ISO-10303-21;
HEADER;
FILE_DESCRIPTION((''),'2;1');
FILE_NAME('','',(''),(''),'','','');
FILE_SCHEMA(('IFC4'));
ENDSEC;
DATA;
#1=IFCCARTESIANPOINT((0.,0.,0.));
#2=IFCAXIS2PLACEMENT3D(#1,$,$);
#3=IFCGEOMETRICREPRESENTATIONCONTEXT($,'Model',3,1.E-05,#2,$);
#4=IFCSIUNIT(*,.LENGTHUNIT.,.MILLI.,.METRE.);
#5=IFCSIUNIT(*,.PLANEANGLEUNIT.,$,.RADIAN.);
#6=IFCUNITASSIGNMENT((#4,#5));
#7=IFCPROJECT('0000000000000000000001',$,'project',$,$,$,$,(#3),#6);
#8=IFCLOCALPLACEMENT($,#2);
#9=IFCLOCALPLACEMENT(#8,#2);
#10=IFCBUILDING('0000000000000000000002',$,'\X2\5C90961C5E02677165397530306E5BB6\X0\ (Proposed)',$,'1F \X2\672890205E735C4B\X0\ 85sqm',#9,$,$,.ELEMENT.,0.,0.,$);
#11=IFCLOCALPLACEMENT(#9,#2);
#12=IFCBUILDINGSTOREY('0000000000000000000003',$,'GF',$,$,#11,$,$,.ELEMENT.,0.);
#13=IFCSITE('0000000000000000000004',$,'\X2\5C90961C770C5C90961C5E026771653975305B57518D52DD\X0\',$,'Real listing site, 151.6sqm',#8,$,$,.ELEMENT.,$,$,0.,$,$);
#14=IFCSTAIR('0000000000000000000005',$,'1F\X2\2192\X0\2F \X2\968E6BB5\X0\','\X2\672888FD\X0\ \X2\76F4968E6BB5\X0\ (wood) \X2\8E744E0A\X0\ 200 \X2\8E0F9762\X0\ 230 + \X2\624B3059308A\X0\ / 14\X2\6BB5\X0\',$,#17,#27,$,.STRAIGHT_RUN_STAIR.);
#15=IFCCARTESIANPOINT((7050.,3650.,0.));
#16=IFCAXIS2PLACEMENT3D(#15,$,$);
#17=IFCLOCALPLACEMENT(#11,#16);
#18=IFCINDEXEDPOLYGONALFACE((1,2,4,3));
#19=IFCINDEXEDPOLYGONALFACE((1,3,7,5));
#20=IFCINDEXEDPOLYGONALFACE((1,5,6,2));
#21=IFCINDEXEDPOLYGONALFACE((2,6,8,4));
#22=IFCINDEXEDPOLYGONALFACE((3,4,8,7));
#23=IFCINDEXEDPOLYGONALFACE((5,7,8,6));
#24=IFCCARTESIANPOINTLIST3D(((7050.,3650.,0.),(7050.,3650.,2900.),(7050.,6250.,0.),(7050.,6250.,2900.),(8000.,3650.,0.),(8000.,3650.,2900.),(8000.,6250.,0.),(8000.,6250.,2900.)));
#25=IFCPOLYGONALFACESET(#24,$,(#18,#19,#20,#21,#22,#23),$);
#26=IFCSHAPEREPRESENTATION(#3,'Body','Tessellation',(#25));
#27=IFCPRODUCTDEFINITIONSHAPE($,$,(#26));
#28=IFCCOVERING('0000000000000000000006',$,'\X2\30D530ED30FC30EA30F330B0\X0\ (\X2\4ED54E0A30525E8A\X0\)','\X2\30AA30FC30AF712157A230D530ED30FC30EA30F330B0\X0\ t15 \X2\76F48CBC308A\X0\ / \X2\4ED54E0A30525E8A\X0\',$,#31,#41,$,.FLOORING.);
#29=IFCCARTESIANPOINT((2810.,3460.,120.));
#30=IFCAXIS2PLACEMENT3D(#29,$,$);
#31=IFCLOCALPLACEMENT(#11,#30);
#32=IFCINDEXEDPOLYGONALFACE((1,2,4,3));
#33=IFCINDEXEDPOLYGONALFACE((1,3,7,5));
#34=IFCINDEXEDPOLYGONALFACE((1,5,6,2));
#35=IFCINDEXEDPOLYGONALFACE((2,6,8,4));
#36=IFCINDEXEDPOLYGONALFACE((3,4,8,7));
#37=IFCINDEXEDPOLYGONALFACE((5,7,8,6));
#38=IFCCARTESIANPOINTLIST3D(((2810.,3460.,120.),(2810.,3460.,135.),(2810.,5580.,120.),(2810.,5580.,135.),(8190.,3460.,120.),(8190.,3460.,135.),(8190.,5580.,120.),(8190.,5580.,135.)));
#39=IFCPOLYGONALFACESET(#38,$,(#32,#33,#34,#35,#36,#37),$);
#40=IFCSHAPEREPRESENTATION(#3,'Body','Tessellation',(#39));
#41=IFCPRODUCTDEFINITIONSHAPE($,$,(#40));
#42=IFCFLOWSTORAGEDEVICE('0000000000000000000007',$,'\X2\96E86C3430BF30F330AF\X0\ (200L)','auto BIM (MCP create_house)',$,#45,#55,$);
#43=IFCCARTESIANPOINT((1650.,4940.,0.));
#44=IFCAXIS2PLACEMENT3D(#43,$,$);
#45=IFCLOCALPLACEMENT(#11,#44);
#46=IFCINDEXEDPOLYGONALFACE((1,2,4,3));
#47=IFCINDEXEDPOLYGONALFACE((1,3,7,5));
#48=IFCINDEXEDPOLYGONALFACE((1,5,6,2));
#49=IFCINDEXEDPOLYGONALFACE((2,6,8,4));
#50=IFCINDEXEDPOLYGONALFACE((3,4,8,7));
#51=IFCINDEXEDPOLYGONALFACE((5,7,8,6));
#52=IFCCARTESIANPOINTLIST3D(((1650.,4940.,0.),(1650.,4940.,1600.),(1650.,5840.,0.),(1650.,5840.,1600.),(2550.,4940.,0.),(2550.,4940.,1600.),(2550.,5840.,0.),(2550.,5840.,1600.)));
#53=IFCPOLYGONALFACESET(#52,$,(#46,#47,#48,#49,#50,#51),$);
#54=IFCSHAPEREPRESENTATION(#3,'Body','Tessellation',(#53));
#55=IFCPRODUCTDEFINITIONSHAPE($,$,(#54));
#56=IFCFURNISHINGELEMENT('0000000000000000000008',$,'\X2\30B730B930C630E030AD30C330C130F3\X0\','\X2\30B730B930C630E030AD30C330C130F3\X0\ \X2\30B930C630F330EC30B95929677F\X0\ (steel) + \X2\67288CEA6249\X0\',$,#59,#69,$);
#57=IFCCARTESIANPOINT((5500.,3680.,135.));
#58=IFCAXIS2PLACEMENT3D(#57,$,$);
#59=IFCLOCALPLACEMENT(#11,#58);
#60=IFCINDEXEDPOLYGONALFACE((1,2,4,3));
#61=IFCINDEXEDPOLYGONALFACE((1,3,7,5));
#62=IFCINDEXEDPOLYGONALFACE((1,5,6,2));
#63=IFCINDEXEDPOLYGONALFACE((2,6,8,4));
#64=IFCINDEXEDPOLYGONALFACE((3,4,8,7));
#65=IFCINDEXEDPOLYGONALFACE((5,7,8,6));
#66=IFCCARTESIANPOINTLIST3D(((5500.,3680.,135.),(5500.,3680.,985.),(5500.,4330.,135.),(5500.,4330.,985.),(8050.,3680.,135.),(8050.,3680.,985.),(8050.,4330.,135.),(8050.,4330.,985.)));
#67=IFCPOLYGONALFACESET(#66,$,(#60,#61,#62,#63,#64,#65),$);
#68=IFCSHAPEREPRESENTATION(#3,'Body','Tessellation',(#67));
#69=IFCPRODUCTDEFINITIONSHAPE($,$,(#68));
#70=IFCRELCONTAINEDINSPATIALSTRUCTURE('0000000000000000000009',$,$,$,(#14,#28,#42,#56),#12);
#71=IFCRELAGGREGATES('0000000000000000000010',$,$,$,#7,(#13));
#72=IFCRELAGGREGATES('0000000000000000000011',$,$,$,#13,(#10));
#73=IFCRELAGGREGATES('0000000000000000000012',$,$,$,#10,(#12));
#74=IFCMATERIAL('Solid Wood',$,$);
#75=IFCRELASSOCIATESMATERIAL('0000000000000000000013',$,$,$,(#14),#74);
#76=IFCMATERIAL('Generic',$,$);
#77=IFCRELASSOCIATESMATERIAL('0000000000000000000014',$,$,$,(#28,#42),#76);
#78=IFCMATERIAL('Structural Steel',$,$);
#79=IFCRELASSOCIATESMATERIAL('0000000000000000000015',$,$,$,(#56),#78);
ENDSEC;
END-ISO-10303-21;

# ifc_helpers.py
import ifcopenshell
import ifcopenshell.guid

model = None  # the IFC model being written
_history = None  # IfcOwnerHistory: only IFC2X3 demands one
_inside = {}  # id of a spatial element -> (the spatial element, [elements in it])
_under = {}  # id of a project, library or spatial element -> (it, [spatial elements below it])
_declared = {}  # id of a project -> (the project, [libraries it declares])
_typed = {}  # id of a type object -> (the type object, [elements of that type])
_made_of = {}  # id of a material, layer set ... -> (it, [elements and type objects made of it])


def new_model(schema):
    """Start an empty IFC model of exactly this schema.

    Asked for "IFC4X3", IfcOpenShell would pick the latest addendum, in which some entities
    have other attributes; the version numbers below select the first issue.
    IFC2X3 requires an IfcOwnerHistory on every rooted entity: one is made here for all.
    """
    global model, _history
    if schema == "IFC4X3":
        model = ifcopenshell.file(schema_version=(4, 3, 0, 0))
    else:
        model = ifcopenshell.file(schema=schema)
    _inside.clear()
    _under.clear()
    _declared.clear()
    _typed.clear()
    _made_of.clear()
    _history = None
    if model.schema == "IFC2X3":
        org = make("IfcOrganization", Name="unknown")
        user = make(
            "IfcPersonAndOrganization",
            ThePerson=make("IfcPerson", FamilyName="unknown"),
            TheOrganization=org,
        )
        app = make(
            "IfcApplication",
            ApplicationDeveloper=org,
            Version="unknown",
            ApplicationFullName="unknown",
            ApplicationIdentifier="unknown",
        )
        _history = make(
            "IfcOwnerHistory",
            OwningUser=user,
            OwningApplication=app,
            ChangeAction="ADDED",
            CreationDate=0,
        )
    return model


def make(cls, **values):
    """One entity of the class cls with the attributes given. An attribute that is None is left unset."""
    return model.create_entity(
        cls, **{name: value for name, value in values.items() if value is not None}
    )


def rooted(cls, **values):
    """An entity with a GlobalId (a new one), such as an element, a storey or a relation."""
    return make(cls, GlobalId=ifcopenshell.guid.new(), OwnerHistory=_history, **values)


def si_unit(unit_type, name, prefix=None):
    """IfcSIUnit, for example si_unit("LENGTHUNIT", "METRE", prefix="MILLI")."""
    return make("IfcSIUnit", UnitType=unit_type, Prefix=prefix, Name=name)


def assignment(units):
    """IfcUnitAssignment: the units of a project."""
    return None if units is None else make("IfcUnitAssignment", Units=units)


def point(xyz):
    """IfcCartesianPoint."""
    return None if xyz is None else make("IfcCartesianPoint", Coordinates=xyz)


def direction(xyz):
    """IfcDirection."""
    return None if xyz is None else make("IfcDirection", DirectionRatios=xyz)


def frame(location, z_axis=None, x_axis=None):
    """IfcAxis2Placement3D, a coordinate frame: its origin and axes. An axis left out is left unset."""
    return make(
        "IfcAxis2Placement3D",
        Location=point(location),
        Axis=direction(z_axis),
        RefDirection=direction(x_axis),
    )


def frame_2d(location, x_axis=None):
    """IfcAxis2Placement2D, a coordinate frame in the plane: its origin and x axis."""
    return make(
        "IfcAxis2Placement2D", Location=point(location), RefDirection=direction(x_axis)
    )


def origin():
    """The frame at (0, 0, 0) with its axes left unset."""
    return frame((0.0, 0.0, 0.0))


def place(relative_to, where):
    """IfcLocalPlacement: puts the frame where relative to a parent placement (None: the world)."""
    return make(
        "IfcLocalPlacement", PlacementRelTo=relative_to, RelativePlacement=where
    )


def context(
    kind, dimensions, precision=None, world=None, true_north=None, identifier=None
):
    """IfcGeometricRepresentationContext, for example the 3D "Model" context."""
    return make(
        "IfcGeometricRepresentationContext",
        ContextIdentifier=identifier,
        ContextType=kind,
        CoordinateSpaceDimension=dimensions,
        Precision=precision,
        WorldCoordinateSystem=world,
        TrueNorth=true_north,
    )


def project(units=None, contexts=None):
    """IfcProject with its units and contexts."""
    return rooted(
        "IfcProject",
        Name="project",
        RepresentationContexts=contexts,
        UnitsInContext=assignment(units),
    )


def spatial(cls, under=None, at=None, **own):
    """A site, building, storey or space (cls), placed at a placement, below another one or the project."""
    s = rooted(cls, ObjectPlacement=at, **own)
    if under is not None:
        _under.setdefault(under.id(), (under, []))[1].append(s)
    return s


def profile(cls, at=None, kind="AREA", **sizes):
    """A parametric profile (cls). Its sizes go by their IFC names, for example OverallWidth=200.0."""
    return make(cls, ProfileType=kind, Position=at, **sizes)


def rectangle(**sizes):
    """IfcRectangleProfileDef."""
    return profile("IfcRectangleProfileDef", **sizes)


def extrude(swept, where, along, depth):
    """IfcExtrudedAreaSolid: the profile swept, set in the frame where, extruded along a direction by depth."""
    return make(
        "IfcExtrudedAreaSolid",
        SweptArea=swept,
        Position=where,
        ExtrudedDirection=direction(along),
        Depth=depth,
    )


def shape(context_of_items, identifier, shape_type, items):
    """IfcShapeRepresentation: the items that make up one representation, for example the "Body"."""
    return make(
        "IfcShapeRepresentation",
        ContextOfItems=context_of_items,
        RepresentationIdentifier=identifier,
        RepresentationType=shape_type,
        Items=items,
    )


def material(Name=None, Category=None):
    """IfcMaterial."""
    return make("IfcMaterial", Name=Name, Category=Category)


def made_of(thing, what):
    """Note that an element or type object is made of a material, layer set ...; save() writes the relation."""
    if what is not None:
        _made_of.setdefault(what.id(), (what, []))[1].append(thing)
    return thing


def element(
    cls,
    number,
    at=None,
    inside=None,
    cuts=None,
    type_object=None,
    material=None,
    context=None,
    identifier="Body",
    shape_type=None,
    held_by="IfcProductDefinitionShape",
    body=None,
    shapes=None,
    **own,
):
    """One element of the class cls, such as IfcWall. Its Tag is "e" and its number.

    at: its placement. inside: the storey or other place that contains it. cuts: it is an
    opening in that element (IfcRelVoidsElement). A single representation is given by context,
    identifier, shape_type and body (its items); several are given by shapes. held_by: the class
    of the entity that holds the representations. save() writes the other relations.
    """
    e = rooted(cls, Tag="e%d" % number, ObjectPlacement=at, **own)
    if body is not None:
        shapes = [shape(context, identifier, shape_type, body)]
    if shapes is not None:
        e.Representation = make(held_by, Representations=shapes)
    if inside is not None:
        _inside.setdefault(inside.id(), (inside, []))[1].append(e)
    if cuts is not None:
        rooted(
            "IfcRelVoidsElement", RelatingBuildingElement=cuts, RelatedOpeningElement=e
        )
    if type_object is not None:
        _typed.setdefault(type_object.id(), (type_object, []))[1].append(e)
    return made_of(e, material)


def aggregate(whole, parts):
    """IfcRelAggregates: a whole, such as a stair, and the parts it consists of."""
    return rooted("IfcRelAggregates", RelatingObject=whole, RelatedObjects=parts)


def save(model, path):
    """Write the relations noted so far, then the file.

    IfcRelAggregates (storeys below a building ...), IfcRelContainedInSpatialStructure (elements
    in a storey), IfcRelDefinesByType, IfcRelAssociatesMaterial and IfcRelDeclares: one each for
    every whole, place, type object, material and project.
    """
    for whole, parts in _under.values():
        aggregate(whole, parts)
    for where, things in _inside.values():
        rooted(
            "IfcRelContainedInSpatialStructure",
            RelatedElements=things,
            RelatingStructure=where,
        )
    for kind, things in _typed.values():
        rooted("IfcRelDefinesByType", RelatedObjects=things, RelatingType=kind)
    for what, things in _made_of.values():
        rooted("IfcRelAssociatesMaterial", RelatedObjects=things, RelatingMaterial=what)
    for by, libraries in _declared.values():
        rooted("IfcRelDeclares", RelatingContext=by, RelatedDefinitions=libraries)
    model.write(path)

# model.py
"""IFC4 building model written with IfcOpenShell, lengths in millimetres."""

from ifc_helpers import new_model, si_unit, frame, frame_2d, origin, place, context, project, spatial, rectangle, extrude, material, element, save


model = new_model("IFC4")

# Units and contexts
model_context = context("Model", 3, precision=1e-05, world=origin())
ifc_project = project(units=[si_unit("LENGTHUNIT", "METRE", prefix="MILLI"), si_unit("PLANEANGLEUNIT", "RADIAN")], contexts=[model_context])

# Site, building, storey
site_placement = place(None, origin())
site = spatial("IfcSite", under=ifc_project, at=site_placement, Name="岐阜県岐阜市東改田字再勝", ObjectType="Real listing site, 151.6sqm", CompositionType="ELEMENT", RefElevation=0.0)
building_placement = place(site_placement, origin())
building = spatial("IfcBuilding", under=site, at=building_placement, Name="岐阜市東改田の家 (Proposed)", ObjectType="1F 木造平屋 85sqm", CompositionType="ELEMENT", ElevationOfRefHeight=0.0, ElevationOfTerrain=0.0)
storey_placement = place(building_placement, origin())
storey = spatial("IfcBuildingStorey", under=building, at=storey_placement, Name="GF", CompositionType="ELEMENT", Elevation=0.0)

# Shared definitions
ifc_material_1 = material(Name="Solid Wood")
ifc_material_2 = material(Name="Generic")

# Stair
stair_placement = place(storey_placement, frame((7050.0, 3650.0, 0.0)))
element("IfcStair", 1, at=stair_placement, inside=storey, material=ifc_material_1, Name="1F→2F 階段", Description="木製 直階段 (wood) 蹴上 200 踏面 230 + 手すり / 14段", PredefinedType="STRAIGHT_RUN_STAIR", context=model_context, shape_type="SweptSolid", body=[
    extrude(rectangle(XDim=950.0, YDim=2600.0, at=frame_2d((475.0, 1300.0))), frame((7050.0, 3650.0, 0.0)), (0.0, 0.0, 1.0), 2900.0),
])

# Covering
covering_placement = place(storey_placement, frame((2810.0, 3460.0, 120.0)))
element("IfcCovering", 2, at=covering_placement, inside=storey, material=ifc_material_2, Name="フローリング (仕上げ床)", Description="オーク無垢フローリング t15 直貼り / 仕上げ床", PredefinedType="FLOORING", context=model_context, shape_type="SweptSolid", body=[
    extrude(rectangle(XDim=5380.0, YDim=2120.0, at=frame_2d((2690.0, 1060.0))), frame((2810.0, 3460.0, 120.0)), (0.0, 0.0, 1.0), 15.0),
])

# Flow storage device
flow_storage_device_placement = place(storey_placement, frame((1650.0, 4940.0, 0.0)))
element("IfcFlowStorageDevice", 3, at=flow_storage_device_placement, inside=storey, material=ifc_material_2, Name="雨水タンク (200L)", Description="auto BIM (MCP create_house)", context=model_context, shape_type="SweptSolid", body=[
    extrude(rectangle(XDim=900.0, YDim=900.0, at=frame_2d((450.0, 450.0))), frame((1650.0, 4940.0, 0.0)), (0.0, 0.0, 1.0), 1600.0),
])

# Furnishing element
ifc_material_3 = material(Name="Structural Steel")
furnishing_placement = place(storey_placement, frame((5500.0, 3680.0, 135.0)))
element("IfcFurnishingElement", 4, at=furnishing_placement, inside=storey, material=ifc_material_3, Name="システムキッチン", Description="システムキッチン ステンレス天板 (steel) + 木質扉", context=model_context, shape_type="SweptSolid", body=[
    extrude(rectangle(XDim=2550.0, YDim=650.0, at=frame_2d((1275.0, 325.0))), frame((5500.0, 3680.0, 135.0)), (0.0, 0.0, 1.0), 850.0),
])

save(model, "model.ifc")
